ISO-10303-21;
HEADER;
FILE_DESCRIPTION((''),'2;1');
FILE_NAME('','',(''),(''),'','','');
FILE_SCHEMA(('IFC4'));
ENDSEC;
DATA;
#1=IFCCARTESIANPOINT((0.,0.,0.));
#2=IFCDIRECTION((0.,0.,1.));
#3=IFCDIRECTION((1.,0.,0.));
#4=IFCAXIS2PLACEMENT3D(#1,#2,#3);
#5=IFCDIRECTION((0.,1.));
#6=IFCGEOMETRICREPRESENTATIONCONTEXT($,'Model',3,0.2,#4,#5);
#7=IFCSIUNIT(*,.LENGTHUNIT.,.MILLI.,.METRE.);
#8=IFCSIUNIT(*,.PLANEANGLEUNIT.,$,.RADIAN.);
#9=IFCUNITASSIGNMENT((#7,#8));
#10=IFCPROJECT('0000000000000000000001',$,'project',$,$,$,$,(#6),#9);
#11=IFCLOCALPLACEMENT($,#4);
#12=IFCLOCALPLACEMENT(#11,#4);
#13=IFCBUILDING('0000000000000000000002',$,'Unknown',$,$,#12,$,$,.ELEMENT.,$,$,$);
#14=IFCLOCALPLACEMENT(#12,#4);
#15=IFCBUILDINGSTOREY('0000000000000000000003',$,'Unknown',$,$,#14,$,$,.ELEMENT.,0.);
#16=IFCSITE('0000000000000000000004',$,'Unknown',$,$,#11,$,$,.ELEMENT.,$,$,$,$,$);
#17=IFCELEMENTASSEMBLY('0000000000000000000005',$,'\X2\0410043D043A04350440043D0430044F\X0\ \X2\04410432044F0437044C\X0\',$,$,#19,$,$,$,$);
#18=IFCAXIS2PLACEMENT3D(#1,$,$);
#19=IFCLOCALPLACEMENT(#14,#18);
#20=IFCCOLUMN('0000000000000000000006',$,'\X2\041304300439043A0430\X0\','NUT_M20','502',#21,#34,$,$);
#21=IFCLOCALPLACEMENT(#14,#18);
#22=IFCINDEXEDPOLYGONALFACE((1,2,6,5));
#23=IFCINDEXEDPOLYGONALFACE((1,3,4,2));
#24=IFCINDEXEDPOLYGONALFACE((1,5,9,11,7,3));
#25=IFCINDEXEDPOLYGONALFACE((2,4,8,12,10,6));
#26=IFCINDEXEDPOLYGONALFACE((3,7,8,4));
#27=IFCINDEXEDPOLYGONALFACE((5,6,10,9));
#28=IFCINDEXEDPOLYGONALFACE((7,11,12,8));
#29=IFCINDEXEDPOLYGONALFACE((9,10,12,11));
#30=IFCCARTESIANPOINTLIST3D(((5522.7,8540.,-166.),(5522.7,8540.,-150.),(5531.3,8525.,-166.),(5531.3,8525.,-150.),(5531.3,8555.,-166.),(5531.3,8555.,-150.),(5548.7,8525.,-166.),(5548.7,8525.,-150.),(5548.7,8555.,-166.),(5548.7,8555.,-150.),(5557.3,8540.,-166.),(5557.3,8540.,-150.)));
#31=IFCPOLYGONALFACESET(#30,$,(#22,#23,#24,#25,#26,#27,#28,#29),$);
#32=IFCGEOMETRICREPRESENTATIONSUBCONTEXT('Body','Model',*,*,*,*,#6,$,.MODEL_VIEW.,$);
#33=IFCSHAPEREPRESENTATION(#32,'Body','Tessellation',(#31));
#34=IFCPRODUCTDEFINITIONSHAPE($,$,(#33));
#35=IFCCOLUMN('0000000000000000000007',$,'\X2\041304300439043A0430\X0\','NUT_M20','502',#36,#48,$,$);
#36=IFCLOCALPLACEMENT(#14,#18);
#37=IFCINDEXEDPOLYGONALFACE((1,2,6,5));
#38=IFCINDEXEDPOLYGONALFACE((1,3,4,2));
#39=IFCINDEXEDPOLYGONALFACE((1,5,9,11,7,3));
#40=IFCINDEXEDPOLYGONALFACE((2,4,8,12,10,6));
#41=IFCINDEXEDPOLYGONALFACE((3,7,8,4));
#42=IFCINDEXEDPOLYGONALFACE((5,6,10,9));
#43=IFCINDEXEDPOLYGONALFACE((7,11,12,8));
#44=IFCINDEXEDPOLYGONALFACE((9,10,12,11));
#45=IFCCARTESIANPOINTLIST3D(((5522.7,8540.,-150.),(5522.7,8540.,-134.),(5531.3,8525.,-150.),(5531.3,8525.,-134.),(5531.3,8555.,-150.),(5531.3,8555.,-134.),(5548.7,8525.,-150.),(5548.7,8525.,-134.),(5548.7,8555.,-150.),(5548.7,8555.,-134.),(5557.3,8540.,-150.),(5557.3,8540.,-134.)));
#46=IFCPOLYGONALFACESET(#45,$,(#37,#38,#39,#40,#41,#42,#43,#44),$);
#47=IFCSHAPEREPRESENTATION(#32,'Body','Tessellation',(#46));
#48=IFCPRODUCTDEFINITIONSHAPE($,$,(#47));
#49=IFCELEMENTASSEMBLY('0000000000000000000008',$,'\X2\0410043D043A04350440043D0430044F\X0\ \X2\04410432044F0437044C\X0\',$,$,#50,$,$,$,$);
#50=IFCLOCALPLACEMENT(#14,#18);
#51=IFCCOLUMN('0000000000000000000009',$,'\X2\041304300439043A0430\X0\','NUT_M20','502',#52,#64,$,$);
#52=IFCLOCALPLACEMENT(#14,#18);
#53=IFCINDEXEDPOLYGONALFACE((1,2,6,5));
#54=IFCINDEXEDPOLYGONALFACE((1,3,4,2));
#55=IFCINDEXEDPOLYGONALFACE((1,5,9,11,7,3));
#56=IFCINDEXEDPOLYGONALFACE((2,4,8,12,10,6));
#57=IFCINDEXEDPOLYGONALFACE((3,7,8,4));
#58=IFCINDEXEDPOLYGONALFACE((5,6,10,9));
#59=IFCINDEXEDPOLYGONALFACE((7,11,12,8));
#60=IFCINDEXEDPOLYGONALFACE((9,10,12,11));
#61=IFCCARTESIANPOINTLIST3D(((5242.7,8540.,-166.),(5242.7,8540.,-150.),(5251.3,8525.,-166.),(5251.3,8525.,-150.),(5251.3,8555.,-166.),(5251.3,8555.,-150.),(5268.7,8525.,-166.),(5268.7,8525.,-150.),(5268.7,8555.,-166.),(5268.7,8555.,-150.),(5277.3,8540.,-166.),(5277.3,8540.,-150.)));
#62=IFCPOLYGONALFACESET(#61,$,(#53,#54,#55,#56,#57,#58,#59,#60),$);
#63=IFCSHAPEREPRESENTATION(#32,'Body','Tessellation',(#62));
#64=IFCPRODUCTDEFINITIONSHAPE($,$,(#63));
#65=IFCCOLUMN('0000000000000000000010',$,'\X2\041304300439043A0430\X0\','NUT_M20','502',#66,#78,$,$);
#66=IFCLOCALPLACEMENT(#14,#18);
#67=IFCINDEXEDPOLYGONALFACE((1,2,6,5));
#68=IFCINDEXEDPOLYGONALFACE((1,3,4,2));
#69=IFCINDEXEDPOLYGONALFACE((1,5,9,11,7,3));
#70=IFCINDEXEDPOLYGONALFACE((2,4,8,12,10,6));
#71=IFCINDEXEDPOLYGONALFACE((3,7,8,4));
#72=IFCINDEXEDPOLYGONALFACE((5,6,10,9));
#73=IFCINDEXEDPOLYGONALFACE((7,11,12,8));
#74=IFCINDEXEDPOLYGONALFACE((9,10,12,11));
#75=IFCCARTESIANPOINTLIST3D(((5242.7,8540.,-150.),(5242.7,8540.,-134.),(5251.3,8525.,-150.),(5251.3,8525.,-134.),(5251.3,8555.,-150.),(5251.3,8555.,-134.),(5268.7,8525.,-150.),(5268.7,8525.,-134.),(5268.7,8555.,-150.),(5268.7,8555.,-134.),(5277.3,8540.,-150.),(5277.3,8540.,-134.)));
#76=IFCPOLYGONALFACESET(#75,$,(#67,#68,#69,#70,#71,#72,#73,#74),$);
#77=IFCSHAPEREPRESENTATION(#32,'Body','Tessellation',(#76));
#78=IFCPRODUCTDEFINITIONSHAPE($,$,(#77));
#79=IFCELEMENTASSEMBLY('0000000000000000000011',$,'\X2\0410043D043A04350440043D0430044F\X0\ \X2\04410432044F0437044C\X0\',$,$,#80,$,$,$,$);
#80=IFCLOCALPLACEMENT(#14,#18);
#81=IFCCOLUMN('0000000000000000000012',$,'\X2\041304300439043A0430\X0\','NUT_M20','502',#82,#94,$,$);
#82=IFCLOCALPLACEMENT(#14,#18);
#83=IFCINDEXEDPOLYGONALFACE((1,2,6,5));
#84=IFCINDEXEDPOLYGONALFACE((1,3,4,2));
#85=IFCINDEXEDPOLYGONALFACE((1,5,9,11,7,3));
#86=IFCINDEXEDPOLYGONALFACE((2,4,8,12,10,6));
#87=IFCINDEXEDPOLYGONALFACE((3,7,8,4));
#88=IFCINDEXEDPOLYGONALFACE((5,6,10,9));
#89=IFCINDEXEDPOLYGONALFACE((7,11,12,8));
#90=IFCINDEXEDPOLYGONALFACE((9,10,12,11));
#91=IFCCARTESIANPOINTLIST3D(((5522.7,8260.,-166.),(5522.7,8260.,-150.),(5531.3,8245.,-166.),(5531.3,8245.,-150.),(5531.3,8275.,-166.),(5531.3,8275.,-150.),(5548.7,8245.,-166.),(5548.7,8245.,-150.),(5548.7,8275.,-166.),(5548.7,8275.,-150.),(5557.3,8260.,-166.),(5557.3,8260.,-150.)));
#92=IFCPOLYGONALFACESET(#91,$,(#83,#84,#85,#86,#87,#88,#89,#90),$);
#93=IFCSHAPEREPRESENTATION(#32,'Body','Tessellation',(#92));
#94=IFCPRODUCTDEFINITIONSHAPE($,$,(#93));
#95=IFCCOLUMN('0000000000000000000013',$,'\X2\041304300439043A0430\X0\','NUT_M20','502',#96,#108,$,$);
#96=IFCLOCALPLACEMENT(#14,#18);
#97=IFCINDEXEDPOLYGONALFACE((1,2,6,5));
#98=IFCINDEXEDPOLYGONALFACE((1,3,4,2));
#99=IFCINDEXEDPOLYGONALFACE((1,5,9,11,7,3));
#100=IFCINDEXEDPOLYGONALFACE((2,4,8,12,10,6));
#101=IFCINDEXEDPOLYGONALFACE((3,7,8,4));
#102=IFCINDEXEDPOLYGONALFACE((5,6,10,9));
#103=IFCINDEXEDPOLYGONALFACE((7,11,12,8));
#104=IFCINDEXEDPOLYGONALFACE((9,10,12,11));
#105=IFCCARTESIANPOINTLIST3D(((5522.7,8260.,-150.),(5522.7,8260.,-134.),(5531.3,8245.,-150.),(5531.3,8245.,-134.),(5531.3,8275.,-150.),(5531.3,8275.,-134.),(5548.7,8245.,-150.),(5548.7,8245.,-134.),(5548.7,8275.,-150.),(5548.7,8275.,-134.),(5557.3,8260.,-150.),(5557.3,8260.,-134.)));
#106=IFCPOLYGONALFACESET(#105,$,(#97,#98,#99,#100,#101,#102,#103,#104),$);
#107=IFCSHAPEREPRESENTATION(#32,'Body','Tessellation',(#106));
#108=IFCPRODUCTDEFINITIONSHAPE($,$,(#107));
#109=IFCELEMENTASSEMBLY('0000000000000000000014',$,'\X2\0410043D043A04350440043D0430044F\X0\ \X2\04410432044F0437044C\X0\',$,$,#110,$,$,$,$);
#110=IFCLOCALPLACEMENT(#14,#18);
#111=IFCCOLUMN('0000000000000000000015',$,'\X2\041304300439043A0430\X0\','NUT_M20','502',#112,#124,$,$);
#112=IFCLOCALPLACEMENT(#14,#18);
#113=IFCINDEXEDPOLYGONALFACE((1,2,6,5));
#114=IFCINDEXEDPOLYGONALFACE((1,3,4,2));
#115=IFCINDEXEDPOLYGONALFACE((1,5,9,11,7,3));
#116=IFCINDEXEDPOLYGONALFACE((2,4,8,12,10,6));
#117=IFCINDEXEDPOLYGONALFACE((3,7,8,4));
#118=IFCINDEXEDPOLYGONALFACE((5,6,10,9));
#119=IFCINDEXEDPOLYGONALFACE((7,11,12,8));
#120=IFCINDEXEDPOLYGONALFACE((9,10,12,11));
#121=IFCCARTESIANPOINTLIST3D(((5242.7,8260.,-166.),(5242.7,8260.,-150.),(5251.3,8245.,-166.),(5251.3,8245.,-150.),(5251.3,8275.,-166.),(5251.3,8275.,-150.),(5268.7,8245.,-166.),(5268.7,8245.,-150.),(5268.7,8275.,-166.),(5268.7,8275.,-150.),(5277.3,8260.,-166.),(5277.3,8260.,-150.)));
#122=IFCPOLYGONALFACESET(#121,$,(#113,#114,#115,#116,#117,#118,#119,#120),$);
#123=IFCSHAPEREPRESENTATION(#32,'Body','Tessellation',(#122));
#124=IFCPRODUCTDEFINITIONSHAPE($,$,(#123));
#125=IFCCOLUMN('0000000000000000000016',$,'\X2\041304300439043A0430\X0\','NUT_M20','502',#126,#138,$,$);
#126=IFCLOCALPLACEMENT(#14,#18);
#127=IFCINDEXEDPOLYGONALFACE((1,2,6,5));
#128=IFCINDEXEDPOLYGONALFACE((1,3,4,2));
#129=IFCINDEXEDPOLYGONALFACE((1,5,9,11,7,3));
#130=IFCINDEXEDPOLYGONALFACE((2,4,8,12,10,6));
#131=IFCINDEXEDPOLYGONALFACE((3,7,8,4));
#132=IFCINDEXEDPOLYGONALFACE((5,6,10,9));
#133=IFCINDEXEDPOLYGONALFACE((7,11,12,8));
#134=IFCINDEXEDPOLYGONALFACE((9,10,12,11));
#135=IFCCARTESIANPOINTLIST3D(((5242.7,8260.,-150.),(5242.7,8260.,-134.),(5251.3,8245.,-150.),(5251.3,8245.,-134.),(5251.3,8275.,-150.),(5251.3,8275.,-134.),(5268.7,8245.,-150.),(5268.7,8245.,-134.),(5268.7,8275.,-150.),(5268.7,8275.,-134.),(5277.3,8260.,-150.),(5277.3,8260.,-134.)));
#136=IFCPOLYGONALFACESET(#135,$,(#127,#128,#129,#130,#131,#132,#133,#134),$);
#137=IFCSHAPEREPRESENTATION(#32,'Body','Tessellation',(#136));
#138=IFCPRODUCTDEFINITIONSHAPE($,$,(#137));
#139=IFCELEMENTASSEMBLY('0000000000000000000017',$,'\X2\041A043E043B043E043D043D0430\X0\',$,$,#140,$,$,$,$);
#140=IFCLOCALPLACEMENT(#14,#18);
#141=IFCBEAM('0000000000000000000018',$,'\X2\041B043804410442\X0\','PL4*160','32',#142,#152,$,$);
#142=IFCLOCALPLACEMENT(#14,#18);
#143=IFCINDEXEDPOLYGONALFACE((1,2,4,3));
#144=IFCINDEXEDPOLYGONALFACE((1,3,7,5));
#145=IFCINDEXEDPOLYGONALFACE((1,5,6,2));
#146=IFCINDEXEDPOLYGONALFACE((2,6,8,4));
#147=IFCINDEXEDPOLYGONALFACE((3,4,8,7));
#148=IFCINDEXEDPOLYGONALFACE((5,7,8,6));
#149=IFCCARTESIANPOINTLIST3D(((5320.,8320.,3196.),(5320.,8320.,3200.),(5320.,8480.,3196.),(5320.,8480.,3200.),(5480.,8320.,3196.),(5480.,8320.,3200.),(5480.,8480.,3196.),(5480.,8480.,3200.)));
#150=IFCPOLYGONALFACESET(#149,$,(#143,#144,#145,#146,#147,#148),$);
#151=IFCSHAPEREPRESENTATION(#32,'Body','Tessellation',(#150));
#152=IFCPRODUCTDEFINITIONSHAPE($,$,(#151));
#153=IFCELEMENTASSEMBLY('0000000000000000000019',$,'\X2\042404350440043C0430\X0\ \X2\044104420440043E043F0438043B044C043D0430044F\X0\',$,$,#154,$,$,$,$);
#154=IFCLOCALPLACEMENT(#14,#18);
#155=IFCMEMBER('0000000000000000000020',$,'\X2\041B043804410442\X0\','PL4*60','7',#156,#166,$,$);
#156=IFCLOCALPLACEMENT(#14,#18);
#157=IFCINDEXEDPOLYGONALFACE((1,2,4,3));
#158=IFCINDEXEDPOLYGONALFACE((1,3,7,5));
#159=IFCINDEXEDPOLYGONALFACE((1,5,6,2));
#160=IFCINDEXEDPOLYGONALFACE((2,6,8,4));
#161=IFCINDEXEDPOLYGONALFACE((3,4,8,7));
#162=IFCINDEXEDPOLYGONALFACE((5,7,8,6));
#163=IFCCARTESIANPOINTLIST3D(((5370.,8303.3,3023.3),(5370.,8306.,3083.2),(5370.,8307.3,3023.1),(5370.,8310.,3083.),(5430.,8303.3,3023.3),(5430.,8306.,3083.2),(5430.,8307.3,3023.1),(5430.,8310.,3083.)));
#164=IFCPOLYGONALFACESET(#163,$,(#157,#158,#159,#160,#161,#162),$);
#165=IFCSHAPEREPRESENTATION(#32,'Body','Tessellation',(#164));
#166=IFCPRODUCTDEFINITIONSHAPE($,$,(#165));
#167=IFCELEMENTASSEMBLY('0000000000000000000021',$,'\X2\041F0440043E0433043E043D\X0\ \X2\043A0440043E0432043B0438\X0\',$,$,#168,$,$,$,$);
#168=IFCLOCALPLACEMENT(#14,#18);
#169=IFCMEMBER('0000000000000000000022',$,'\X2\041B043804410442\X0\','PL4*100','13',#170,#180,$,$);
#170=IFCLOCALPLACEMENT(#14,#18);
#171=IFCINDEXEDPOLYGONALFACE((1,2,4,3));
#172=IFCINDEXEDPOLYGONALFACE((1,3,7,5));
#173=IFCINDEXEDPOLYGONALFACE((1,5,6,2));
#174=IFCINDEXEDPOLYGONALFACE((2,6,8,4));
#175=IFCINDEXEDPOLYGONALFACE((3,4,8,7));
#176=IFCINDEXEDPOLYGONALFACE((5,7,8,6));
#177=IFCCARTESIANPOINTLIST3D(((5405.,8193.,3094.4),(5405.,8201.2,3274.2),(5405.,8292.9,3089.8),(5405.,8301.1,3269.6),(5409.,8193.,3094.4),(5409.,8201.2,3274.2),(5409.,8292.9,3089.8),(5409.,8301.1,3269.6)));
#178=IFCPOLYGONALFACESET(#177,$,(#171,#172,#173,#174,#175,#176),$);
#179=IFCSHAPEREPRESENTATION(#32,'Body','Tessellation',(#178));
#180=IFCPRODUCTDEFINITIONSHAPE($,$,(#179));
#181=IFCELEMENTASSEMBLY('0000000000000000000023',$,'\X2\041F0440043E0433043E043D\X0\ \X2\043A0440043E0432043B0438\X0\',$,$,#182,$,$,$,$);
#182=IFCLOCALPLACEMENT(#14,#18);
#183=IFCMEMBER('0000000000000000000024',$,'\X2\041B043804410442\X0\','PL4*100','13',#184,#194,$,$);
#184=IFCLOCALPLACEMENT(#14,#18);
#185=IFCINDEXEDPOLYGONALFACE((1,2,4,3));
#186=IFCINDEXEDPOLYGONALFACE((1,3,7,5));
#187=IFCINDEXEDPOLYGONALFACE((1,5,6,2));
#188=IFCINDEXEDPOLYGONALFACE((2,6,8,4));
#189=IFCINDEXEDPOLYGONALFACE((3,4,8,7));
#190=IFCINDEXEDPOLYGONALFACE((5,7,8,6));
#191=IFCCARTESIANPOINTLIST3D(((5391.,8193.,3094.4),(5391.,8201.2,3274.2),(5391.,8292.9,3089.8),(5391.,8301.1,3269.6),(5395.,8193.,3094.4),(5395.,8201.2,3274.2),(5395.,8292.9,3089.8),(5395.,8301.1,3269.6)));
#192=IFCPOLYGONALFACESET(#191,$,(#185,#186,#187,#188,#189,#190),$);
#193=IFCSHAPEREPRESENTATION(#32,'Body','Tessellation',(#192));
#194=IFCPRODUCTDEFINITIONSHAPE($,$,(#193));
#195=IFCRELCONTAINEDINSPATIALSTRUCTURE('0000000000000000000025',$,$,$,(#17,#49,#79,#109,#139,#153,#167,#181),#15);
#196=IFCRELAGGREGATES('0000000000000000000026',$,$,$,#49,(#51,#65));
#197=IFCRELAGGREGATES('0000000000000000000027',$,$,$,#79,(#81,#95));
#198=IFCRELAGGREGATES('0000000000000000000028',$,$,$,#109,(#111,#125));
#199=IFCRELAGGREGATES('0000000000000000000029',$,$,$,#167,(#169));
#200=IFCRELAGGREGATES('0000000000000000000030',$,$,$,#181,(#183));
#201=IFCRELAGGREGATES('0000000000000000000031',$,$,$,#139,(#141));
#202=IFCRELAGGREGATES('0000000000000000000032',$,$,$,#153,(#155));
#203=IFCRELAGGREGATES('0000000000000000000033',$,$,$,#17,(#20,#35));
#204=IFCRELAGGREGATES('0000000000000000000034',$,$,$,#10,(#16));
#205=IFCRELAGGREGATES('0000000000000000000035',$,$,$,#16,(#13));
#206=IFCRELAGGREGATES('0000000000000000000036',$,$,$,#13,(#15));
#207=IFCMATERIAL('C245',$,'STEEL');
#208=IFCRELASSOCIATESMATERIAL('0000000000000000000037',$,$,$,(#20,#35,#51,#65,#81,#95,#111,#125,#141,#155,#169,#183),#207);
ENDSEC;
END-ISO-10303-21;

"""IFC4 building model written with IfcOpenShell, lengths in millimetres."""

from ifc_helpers import new_model, si_unit, direction, frame, origin_with_axes, place, context, subcontext, project, spatial, line, indexed_curve, outline, extrude, material, element, aggregate, save


model = new_model("IFC4")

# Units and contexts
model_context = context("Model", 3, precision=0.2, world=origin_with_axes(), true_north=direction((0.0, 1.0)))
body_context = subcontext(model_context, "Body", "Model", "MODEL_VIEW")
ifc_project = project(units=[si_unit("LENGTHUNIT", "METRE", prefix="MILLI"), si_unit("PLANEANGLEUNIT", "RADIAN")], contexts=[model_context])

# Site, building, storey
site_placement = place(None, origin_with_axes())
site = spatial("IfcSite", under=ifc_project, at=site_placement, Name="Unknown", CompositionType="ELEMENT")
building_placement = place(site_placement, origin_with_axes())
building = spatial("IfcBuilding", under=site, at=building_placement, Name="Unknown", CompositionType="ELEMENT")
storey_placement = place(building_placement, origin_with_axes())
storey = spatial("IfcBuildingStorey", under=building, at=storey_placement, Name="Unknown", CompositionType="ELEMENT", Elevation=0.0)

# Element assemblies, columns
assembly_1_placement = place(storey_placement, frame((5540.0, 8540.0, -125.0), z_axis=(-1.0, 0.0, 0.0), x_axis=(0.0, 0.0, -1.0)))
assembly_1 = element("IfcElementAssembly", 1, at=assembly_1_placement, inside=storey, Name="Анкерная связь")
ifc_material_1 = material(Name="C245", Category="STEEL")
column_1_placement = place(assembly_1_placement, frame((25.0, 0.0, 0.0), z_axis=(0.0, 0.0, -1.0), x_axis=(1.0, 0.0, 0.0)))
column_1 = element("IfcColumn", 2, at=column_1_placement, material=ifc_material_1, Name="Гайка", Description="NUT_M20", ObjectType="502", context=body_context, shape_type="SolidModel", body=[
    extrude(outline(indexed_curve([(8.7, -15.0), (17.3, 0.0), (8.7, 15.0), (-8.7, 15.0), (-17.3, 0.0), (-8.7, -15.0)], segments=[line(1, 2, 3, 4, 5, 6, 1)])), frame((0.0, 0.0, 0.0), z_axis=(-1.0, 0.0, 0.0), x_axis=(0.0, 0.0, 1.0)), (0.0, 0.0, -1.0), 16.0),
])
column_2_placement = place(assembly_1_placement, frame((9.0, 0.0, 0.0), z_axis=(0.0, 0.0, -1.0), x_axis=(1.0, 0.0, 0.0)))
column_2 = element("IfcColumn", 3, at=column_2_placement, material=ifc_material_1, Name="Гайка", Description="NUT_M20", ObjectType="502", context=body_context, shape_type="SolidModel", body=[
    extrude(outline(indexed_curve([(8.7, -15.0), (17.3, 0.0), (8.7, 15.0), (-8.7, 15.0), (-17.3, 0.0), (-8.7, -15.0)], segments=[line(1, 2, 3, 4, 5, 6, 1)])), frame((0.0, 0.0, 0.0), z_axis=(-1.0, 0.0, 0.0), x_axis=(0.0, 0.0, 1.0)), (0.0, 0.0, -1.0), 16.0),
])
assembly_2_placement = place(storey_placement, frame((5260.0, 8540.0, -125.0), z_axis=(1.0, 0.0, 0.0), x_axis=(0.0, 0.0, -1.0)))
assembly_2 = element("IfcElementAssembly", 4, at=assembly_2_placement, inside=storey, Name="Анкерная связь")
column_3_placement = place(assembly_2_placement, frame((25.0, 0.0, 0.0), z_axis=(0.0, 0.0, -1.0), x_axis=(1.0, 0.0, 0.0)))
column_3 = element("IfcColumn", 5, at=column_3_placement, material=ifc_material_1, Name="Гайка", Description="NUT_M20", ObjectType="502", context=body_context, shape_type="SolidModel", body=[
    extrude(outline(indexed_curve([(8.7, -15.0), (17.3, 0.0), (8.7, 15.0), (-8.7, 15.0), (-17.3, 0.0), (-8.7, -15.0)], segments=[line(1, 2, 3, 4, 5, 6, 1)])), frame((0.0, 0.0, 0.0), z_axis=(-1.0, 0.0, 0.0), x_axis=(0.0, 0.0, 1.0)), (0.0, 0.0, -1.0), 16.0),
])
column_4_placement = place(assembly_2_placement, frame((9.0, 0.0, 0.0), z_axis=(0.0, 0.0, -1.0), x_axis=(1.0, 0.0, 0.0)))
column_4 = element("IfcColumn", 6, at=column_4_placement, material=ifc_material_1, Name="Гайка", Description="NUT_M20", ObjectType="502", context=body_context, shape_type="SolidModel", body=[
    extrude(outline(indexed_curve([(8.7, -15.0), (17.3, 0.0), (8.7, 15.0), (-8.7, 15.0), (-17.3, 0.0), (-8.7, -15.0)], segments=[line(1, 2, 3, 4, 5, 6, 1)])), frame((0.0, 0.0, 0.0), z_axis=(-1.0, 0.0, 0.0), x_axis=(0.0, 0.0, 1.0)), (0.0, 0.0, -1.0), 16.0),
])
assembly_3_placement = place(storey_placement, frame((5540.0, 8260.0, -125.0), z_axis=(1.0, 0.0, 0.0), x_axis=(0.0, 0.0, -1.0)))
assembly_3 = element("IfcElementAssembly", 7, at=assembly_3_placement, inside=storey, Name="Анкерная связь")
column_5_placement = place(assembly_3_placement, frame((25.0, 0.0, 0.0), z_axis=(0.0, 0.0, 1.0), x_axis=(1.0, 0.0, 0.0)))
column_5 = element("IfcColumn", 8, at=column_5_placement, material=ifc_material_1, Name="Гайка", Description="NUT_M20", ObjectType="502", context=body_context, shape_type="SolidModel", body=[
    extrude(outline(indexed_curve([(8.7, -15.0), (17.3, 0.0), (8.7, 15.0), (-8.7, 15.0), (-17.3, 0.0), (-8.7, -15.0)], segments=[line(1, 2, 3, 4, 5, 6, 1)])), frame((0.0, 0.0, 0.0), z_axis=(-1.0, 0.0, 0.0), x_axis=(0.0, 0.0, 1.0)), (0.0, 0.0, -1.0), 16.0),
])
column_6_placement = place(assembly_3_placement, frame((9.0, 0.0, 0.0), z_axis=(0.0, 0.0, 1.0), x_axis=(1.0, 0.0, 0.0)))
column_6 = element("IfcColumn", 9, at=column_6_placement, material=ifc_material_1, Name="Гайка", Description="NUT_M20", ObjectType="502", context=body_context, shape_type="SolidModel", body=[
    extrude(outline(indexed_curve([(8.7, -15.0), (17.3, 0.0), (8.7, 15.0), (-8.7, 15.0), (-17.3, 0.0), (-8.7, -15.0)], segments=[line(1, 2, 3, 4, 5, 6, 1)])), frame((0.0, 0.0, 0.0), z_axis=(-1.0, 0.0, 0.0), x_axis=(0.0, 0.0, 1.0)), (0.0, 0.0, -1.0), 16.0),
])
assembly_4_placement = place(storey_placement, frame((5260.0, 8260.0, -125.0), z_axis=(-1.0, 0.0, 0.0), x_axis=(0.0, 0.0, -1.0)))
assembly_4 = element("IfcElementAssembly", 10, at=assembly_4_placement, inside=storey, Name="Анкерная связь")
column_7_placement = place(assembly_4_placement, frame((25.0, 0.0, 0.0), z_axis=(0.0, 0.0, 1.0), x_axis=(1.0, 0.0, 0.0)))
column_7 = element("IfcColumn", 11, at=column_7_placement, material=ifc_material_1, Name="Гайка", Description="NUT_M20", ObjectType="502", context=body_context, shape_type="SolidModel", body=[
    extrude(outline(indexed_curve([(8.7, -15.0), (17.3, 0.0), (8.7, 15.0), (-8.7, 15.0), (-17.3, 0.0), (-8.7, -15.0)], segments=[line(1, 2, 3, 4, 5, 6, 1)])), frame((0.0, 0.0, 0.0), z_axis=(-1.0, 0.0, 0.0), x_axis=(0.0, 0.0, 1.0)), (0.0, 0.0, -1.0), 16.0),
])
column_8_placement = place(assembly_4_placement, frame((9.0, 0.0, 0.0), z_axis=(0.0, 0.0, 1.0), x_axis=(1.0, 0.0, 0.0)))
column_8 = element("IfcColumn", 12, at=column_8_placement, material=ifc_material_1, Name="Гайка", Description="NUT_M20", ObjectType="502", context=body_context, shape_type="SolidModel", body=[
    extrude(outline(indexed_curve([(8.7, -15.0), (17.3, 0.0), (8.7, 15.0), (-8.7, 15.0), (-17.3, 0.0), (-8.7, -15.0)], segments=[line(1, 2, 3, 4, 5, 6, 1)])), frame((0.0, 0.0, 0.0), z_axis=(-1.0, 0.0, 0.0), x_axis=(0.0, 0.0, 1.0)), (0.0, 0.0, -1.0), 16.0),
])

# Element assembly, beam
assembly_5_placement = place(storey_placement, frame((5400.0, 8400.0, -40.0), z_axis=(-1.0, 0.0, 0.0), x_axis=(0.0, 0.0, 1.0)))
assembly_5 = element("IfcElementAssembly", 13, at=assembly_5_placement, inside=storey, Name="Колонна")
beam_1_placement = place(assembly_5_placement, frame((3238.0, -80.0, 0.0), z_axis=(-1.0, 0.0, 0.0), x_axis=(0.0, 1.0, 0.0)))
beam_1 = element("IfcBeam", 14, at=beam_1_placement, material=ifc_material_1, Name="Лист", Description="PL4*160", ObjectType="32", context=body_context, shape_type="SolidModel", body=[
    extrude(outline(indexed_curve([(-2.0, -80.0), (2.0, -80.0), (2.0, 80.0), (-2.0, 80.0)], segments=[line(1, 2, 3, 4, 1)])), frame((0.0, 0.0, 0.0), z_axis=(-1.0, 0.0, 0.0), x_axis=(0.0, 0.0, 1.0)), (0.0, 0.0, -1.0), 160.0),
])

# Element assembly, member
assembly_6_placement = place(storey_placement, frame((5400.0, 88.6, 3426.7), z_axis=(1.0, 0.0, 0.0), x_axis=(0.0, 0.998969, -0.045408)))
assembly_6 = element("IfcElementAssembly", 15, at=assembly_6_placement, inside=storey, Name="Ферма стропильная")
member_1_placement = place(assembly_6_placement, frame((8226.5, -30.0, 0.0), z_axis=(-1.0, 0.0, 0.0), x_axis=(0.0, 1.0, 0.0)))
member_1 = element("IfcMember", 16, at=member_1_placement, material=ifc_material_1, Name="Лист", Description="PL4*60", ObjectType="7", context=body_context, shape_type="SolidModel", body=[
    extrude(outline(indexed_curve([(-2.0, -30.0), (2.0, -30.0), (2.0, 30.0), (-2.0, 30.0)], segments=[line(1, 2, 3, 4, 1)])), frame((0.0, 0.0, 0.0), z_axis=(-1.0, 0.0, 0.0), x_axis=(0.0, 0.0, 1.0)), (0.0, 0.0, -1.0), 60.0),
])

# Element assembly, member
assembly_7_placement = place(storey_placement, frame((5405.0, 8247.1, 3182.0), z_axis=(0.0, -0.998969, 0.045408), x_axis=(1.0, 0.0, 0.0)))
assembly_7 = element("IfcElementAssembly", 17, at=assembly_7_placement, inside=storey, Name="Прогон кровли")
member_2_placement = place(assembly_7_placement, frame((2.0, -90.0, 0.0), z_axis=(1.0, 0.0, 0.0), x_axis=(0.0, 1.0, 0.0)))
member_2 = element("IfcMember", 18, at=member_2_placement, material=ifc_material_1, Name="Лист", Description="PL4*100", ObjectType="13", context=body_context, shape_type="SolidModel", body=[
    extrude(outline(indexed_curve([(-2.0, -50.0), (2.0, -50.0), (2.0, 50.0), (-2.0, 50.0)], segments=[line(1, 2, 3, 4, 1)])), frame((0.0, 0.0, 0.0), z_axis=(-1.0, 0.0, 0.0), x_axis=(0.0, 0.0, 1.0)), (0.0, 0.0, -1.0), 180.0),
])

# Element assembly, member
assembly_8_placement = place(storey_placement, frame((-595.0, 8247.1, 3182.0), z_axis=(0.0, -0.998969, 0.045408), x_axis=(1.0, 0.0, 0.0)))
assembly_8 = element("IfcElementAssembly", 19, at=assembly_8_placement, inside=storey, Name="Прогон кровли")
member_3_placement = place(assembly_8_placement, frame((5988.0, -90.0, 0.0), z_axis=(-1.0, 0.0, 0.0), x_axis=(0.0, 1.0, 0.0)))
member_3 = element("IfcMember", 20, at=member_3_placement, material=ifc_material_1, Name="Лист", Description="PL4*100", ObjectType="13", context=body_context, shape_type="SolidModel", body=[
    extrude(outline(indexed_curve([(-2.0, -50.0), (2.0, -50.0), (2.0, 50.0), (-2.0, 50.0)], segments=[line(1, 2, 3, 4, 1)])), frame((0.0, 0.0, 0.0), z_axis=(-1.0, 0.0, 0.0), x_axis=(0.0, 0.0, 1.0)), (0.0, 0.0, -1.0), 180.0),
])

aggregate(assembly_2, [column_3, column_4])
aggregate(assembly_3, [column_5, column_6])
aggregate(assembly_4, [column_7, column_8])

aggregate(assembly_7, [member_2])
aggregate(assembly_8, [member_3])

aggregate(assembly_5, [beam_1])
aggregate(assembly_6, [member_1])
aggregate(assembly_1, [column_1, column_2])

save(model, "model.ifc")
